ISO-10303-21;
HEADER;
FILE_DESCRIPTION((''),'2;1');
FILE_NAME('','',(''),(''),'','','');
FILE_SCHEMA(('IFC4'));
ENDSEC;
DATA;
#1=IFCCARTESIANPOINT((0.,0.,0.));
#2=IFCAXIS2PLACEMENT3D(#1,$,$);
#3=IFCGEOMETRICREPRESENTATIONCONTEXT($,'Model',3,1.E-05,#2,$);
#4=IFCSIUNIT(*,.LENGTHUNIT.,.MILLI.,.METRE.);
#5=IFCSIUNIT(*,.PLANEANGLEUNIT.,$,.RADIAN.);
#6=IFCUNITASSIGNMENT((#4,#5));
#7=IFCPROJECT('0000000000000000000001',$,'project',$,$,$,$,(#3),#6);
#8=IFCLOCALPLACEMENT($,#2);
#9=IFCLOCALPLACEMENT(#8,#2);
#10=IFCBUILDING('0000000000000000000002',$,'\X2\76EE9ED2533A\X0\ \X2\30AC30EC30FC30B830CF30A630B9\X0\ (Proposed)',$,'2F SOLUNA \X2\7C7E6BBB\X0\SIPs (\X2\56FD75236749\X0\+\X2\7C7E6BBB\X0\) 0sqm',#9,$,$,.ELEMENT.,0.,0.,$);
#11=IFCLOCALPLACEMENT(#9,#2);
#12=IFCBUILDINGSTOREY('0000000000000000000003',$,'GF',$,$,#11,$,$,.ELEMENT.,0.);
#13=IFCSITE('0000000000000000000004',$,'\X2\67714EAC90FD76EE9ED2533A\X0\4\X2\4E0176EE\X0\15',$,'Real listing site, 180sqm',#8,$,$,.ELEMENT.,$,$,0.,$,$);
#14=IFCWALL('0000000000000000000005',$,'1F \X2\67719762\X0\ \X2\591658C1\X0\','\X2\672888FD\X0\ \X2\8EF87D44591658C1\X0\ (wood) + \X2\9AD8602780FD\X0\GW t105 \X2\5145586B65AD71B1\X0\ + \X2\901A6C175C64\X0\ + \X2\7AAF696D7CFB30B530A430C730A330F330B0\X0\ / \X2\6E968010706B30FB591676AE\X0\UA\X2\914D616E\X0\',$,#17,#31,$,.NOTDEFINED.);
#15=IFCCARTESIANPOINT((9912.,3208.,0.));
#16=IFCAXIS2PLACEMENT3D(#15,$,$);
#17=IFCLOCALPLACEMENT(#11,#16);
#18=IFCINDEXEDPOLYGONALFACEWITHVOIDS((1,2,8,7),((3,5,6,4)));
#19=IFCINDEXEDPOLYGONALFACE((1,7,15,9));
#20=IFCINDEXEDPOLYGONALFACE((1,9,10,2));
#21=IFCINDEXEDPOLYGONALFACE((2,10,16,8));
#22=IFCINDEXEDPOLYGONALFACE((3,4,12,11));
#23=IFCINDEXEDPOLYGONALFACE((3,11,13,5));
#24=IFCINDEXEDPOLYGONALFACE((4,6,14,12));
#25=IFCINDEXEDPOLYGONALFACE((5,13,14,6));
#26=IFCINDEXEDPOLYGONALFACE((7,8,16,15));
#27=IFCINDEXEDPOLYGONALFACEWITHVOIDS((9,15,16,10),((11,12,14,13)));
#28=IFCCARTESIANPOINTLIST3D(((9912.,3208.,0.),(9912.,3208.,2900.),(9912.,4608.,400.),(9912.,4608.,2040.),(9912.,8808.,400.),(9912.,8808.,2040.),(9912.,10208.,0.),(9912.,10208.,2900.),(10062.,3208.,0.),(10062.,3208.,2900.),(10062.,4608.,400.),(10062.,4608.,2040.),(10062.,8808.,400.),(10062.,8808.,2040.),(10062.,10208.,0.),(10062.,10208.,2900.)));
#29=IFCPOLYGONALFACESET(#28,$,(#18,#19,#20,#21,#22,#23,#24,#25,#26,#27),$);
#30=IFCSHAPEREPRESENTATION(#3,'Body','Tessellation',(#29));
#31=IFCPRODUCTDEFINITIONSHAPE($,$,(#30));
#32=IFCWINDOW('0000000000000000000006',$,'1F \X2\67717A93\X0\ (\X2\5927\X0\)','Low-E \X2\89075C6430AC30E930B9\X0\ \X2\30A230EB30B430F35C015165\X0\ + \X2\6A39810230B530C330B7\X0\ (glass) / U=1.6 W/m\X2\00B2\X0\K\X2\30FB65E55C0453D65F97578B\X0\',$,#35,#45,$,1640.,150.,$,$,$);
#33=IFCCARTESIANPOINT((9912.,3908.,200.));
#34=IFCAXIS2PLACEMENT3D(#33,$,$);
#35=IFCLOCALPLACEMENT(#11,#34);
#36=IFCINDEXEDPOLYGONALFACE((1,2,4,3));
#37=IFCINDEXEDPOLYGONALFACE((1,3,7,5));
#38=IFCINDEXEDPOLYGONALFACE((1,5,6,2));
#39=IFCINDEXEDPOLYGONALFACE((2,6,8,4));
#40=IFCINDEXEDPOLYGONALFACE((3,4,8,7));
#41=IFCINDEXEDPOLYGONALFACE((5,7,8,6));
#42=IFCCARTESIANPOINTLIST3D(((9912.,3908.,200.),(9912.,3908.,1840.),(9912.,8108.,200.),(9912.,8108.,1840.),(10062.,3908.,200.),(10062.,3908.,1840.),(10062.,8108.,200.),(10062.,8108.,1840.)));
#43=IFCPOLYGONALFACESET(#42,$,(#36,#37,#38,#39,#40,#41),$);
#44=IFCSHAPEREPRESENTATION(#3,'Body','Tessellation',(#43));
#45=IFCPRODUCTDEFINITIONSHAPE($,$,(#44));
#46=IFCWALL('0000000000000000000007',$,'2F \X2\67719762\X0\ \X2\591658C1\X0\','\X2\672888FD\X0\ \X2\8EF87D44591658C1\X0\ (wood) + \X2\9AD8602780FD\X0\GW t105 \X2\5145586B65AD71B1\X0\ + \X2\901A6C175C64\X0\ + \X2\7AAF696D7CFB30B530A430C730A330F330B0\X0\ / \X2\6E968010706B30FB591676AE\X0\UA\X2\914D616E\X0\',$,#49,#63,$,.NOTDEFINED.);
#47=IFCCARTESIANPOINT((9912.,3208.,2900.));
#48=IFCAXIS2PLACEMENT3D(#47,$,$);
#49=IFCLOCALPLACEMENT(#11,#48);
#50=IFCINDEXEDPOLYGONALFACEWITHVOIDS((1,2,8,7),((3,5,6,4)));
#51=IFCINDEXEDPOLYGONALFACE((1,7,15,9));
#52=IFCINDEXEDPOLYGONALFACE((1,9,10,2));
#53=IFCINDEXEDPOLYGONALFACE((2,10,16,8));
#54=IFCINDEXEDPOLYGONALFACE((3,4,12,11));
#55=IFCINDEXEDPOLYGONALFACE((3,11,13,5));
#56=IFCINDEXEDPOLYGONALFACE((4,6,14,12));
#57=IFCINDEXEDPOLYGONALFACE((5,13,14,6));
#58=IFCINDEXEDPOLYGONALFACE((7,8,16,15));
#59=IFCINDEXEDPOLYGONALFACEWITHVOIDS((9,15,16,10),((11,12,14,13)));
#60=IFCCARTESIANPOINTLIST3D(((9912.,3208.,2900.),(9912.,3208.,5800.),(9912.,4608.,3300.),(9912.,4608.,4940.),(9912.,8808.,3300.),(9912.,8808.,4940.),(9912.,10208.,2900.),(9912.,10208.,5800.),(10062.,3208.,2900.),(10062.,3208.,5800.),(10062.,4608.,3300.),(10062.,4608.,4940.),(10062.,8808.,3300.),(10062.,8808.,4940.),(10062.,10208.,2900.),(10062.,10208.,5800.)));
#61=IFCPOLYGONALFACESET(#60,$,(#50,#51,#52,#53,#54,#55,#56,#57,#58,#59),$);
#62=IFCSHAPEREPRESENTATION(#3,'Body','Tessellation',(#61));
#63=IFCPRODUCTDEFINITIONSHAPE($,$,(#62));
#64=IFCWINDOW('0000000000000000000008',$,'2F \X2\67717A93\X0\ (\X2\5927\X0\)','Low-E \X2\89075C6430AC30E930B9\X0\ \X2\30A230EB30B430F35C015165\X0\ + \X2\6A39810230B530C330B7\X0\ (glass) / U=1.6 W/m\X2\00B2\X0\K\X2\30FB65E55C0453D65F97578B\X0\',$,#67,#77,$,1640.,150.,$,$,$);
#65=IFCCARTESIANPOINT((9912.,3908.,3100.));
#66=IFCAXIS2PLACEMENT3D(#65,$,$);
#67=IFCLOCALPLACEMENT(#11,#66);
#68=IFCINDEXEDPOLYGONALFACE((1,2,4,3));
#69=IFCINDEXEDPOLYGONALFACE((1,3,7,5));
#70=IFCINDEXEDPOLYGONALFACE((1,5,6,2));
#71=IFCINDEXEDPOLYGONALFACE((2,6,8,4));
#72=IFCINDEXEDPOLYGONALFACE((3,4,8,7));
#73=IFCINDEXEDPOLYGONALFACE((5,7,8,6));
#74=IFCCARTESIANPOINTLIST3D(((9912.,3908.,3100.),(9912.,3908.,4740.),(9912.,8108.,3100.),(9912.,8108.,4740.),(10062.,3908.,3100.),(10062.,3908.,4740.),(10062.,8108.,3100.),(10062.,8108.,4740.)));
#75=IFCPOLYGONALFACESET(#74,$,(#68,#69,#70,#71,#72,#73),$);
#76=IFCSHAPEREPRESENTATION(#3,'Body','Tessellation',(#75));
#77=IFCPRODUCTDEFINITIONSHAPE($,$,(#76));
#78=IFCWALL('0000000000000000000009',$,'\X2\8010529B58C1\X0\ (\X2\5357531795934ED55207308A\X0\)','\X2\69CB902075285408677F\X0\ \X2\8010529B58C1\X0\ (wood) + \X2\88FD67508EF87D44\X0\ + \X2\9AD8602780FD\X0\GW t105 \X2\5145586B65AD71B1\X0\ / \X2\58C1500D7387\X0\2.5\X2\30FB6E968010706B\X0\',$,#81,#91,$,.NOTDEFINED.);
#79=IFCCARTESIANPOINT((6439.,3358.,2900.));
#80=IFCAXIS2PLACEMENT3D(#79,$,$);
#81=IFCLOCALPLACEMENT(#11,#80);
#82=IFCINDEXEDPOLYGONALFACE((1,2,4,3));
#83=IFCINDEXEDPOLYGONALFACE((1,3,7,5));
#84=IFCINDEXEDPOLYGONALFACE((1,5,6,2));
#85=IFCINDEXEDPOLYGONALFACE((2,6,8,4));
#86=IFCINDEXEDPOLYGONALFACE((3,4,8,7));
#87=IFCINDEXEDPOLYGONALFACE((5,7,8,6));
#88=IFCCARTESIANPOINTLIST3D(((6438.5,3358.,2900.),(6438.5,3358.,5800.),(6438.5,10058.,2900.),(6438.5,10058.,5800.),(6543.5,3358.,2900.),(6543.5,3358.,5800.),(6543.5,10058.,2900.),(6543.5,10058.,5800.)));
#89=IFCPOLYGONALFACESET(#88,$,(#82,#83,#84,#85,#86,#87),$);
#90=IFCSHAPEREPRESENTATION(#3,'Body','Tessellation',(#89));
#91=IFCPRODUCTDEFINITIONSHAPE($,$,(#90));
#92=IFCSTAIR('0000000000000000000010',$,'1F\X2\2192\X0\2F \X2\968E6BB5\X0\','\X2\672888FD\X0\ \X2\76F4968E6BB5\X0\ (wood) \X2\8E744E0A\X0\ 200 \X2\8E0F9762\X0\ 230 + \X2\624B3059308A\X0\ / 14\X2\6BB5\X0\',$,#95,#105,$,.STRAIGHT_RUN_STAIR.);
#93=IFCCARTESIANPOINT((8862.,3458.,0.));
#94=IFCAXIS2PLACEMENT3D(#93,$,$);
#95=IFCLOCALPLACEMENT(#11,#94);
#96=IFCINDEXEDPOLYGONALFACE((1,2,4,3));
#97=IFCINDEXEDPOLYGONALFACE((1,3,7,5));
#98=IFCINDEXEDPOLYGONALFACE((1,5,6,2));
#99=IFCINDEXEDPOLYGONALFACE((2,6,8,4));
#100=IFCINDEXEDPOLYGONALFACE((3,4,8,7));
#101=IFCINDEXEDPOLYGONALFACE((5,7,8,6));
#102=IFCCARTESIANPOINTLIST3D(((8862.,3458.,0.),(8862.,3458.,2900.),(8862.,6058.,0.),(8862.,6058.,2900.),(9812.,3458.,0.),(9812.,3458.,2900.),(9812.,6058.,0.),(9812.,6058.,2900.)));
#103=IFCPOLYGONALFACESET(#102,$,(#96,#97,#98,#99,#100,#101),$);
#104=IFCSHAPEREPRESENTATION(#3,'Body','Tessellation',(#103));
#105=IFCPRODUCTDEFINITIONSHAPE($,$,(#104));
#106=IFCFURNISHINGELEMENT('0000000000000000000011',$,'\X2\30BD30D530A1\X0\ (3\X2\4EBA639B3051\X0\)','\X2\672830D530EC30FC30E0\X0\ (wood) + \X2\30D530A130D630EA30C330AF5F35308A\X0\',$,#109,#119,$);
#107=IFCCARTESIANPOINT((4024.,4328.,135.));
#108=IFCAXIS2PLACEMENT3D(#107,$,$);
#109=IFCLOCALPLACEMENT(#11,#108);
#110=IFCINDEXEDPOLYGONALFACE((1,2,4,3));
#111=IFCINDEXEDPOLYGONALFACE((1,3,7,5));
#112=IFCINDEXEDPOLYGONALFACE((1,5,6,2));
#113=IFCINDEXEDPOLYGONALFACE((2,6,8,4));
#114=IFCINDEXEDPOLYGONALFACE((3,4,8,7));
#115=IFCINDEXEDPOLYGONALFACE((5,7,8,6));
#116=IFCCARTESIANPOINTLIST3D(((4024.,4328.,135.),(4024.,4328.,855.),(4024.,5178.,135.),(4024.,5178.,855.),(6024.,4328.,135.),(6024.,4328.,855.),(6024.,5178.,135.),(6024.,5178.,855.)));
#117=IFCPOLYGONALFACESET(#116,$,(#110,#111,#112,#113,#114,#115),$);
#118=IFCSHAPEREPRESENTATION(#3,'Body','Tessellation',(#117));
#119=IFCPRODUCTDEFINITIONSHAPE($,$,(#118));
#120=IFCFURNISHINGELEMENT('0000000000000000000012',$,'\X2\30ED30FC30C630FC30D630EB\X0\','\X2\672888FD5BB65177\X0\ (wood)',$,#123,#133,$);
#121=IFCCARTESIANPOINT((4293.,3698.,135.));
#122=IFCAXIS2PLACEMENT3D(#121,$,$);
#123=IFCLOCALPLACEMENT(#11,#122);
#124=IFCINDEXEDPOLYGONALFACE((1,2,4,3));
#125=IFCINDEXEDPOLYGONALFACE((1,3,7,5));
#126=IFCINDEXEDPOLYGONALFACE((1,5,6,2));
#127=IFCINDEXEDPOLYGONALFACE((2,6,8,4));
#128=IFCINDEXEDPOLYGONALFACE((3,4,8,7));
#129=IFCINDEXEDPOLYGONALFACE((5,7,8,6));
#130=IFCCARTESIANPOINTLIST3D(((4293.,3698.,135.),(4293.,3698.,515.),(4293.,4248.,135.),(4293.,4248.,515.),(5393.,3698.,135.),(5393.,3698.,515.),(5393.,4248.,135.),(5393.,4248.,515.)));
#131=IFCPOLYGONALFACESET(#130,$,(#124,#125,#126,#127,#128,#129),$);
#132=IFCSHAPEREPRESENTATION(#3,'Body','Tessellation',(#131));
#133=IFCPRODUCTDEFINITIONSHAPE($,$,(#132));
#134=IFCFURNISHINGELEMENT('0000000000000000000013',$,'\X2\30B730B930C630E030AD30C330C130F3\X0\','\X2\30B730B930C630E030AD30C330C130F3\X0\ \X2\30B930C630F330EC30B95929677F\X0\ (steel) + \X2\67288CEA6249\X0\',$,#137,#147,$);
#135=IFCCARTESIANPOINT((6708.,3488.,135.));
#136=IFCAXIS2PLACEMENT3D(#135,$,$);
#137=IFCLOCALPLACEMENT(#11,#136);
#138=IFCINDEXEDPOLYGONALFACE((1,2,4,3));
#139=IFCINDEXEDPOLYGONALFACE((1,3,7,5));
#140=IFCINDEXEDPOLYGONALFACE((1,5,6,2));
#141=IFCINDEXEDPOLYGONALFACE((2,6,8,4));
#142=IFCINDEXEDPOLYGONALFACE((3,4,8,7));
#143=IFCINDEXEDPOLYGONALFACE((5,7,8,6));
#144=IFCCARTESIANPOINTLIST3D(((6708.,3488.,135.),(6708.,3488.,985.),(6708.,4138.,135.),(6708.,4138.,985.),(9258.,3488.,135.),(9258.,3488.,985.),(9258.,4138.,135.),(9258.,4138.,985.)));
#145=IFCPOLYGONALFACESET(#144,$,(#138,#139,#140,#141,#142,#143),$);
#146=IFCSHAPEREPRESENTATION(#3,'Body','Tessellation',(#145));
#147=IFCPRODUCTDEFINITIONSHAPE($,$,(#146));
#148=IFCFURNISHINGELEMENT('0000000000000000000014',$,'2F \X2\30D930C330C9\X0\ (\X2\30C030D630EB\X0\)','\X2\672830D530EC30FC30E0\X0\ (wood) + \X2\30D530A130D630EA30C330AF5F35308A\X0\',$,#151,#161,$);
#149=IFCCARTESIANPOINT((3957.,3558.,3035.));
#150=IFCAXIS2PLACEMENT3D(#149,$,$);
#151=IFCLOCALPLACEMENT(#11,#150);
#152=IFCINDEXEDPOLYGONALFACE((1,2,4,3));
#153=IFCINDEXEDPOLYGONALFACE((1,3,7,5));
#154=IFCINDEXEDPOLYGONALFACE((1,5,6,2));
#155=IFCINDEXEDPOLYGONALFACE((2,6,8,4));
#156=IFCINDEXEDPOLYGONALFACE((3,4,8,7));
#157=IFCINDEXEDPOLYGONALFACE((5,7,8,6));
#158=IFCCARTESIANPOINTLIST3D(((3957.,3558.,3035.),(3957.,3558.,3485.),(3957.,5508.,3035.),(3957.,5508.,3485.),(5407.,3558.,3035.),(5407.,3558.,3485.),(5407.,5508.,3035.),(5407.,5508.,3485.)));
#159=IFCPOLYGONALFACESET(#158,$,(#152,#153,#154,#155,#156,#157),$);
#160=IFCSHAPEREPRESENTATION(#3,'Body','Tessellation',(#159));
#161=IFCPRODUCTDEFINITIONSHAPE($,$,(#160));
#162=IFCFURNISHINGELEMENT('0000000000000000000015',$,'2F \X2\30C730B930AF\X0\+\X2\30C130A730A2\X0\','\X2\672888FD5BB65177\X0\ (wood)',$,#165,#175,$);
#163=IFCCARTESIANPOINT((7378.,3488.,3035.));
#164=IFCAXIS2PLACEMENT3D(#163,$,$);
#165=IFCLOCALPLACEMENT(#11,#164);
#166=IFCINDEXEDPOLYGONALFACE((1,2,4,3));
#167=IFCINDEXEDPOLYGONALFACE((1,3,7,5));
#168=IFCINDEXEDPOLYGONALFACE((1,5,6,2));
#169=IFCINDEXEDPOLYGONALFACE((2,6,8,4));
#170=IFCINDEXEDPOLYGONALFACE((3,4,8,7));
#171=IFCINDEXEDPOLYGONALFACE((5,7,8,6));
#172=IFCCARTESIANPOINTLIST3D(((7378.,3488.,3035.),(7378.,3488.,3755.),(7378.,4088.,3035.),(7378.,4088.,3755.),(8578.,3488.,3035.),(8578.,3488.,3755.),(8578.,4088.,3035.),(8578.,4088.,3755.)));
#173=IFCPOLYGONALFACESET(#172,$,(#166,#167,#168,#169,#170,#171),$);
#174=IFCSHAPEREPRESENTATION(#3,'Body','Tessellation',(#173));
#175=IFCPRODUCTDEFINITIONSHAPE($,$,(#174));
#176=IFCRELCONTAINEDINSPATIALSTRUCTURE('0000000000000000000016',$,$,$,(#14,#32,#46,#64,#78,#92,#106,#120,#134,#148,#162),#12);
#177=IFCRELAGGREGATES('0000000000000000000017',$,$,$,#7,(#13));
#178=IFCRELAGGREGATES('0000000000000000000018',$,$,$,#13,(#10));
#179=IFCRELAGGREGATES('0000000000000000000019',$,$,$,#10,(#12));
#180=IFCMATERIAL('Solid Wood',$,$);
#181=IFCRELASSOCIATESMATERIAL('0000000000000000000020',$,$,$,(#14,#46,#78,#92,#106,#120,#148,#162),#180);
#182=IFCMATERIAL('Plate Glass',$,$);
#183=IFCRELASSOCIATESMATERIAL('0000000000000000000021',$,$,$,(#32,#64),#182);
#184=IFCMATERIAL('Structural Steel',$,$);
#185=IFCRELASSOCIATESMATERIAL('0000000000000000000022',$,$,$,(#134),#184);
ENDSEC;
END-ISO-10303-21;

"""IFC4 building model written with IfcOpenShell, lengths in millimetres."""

from ifc_helpers import new_model, si_unit, frame, frame_2d, origin, place, context, project, spatial, rectangle, extrude, material, element, fill, save


model = new_model("IFC4")

# Units and contexts
model_context = context("Model", 3, precision=1e-05, world=origin())
ifc_project = project(units=[si_unit("LENGTHUNIT", "METRE", prefix="MILLI"), si_unit("PLANEANGLEUNIT", "RADIAN")], contexts=[model_context])

# Site, building, storey
site_placement = place(None, origin())
site = spatial("IfcSite", under=ifc_project, at=site_placement, Name="東京都目黒区4丁目15", ObjectType="Real listing site, 180sqm", CompositionType="ELEMENT", RefElevation=0.0)
building_placement = place(site_placement, origin())
building = spatial("IfcBuilding", under=site, at=building_placement, Name="目黒区 ガレージハウス (Proposed)", ObjectType="2F SOLUNA 籾殻SIPs (国産杉+籾殻) 0sqm", CompositionType="ELEMENT", ElevationOfRefHeight=0.0, ElevationOfTerrain=0.0)
storey_placement = place(building_placement, origin())
storey = spatial("IfcBuildingStorey", under=building, at=storey_placement, Name="GF", CompositionType="ELEMENT", Elevation=0.0)

# Wall, opening, window
ifc_material_1 = material(Name="Solid Wood")
wall_1_placement = place(storey_placement, frame((9912.0, 3208.0, 0.0)))
wall_1 = element("IfcWall", 1, at=wall_1_placement, inside=storey, material=ifc_material_1, Name="1F 東面 外壁", Description="木製 軸組外壁 (wood) + 高性能GW t105 充填断熱 + 通気層 + 窯業系サイディング / 準耐火・外皮UA配慮", PredefinedType="NOTDEFINED", context=model_context, shape_type="SweptSolid", body=[
    extrude(rectangle(XDim=150.0, YDim=7000.0, at=frame_2d((75.0, 3500.0))), frame((9912.0, 3208.0, 0.0)), (0.0, 0.0, 1.0), 2900.0),
])
opening_1_placement = place(storey_placement, frame((9912.0, 3908.0, 200.0)))
opening_1 = element("IfcOpeningElement", 2, at=opening_1_placement, cuts=wall_1, PredefinedType="NOTDEFINED", context=model_context, shape_type="SweptSolid", body=[
    extrude(rectangle(XDim=150.0, YDim=4200.0, at=frame_2d((75.0, 2100.0))), frame((9912.0, 3908.0, 200.0)), (0.0, 0.0, 1.0), 1640.0),
])
ifc_material_2 = material(Name="Plate Glass")
window_1_placement = place(storey_placement, frame((9912.0, 3908.0, 200.0)))
window_1 = element("IfcWindow", 3, at=window_1_placement, inside=storey, material=ifc_material_2, Name="1F 東窓 (大)", Description="Low-E 複層ガラス アルゴン封入 + 樹脂サッシ (glass) / U=1.6 W/m²K・日射取得型", OverallHeight=1640.0, OverallWidth=150.0, context=model_context, shape_type="SweptSolid", body=[
    extrude(rectangle(XDim=150.0, YDim=4200.0, at=frame_2d((75.0, 2100.0))), frame((9912.0, 3908.0, 200.0)), (0.0, 0.0, 1.0), 1640.0),
])
fill(opening_1, window_1)

# Wall, opening, window
wall_2_placement = place(storey_placement, frame((9912.0, 3208.0, 2900.0)))
wall_2 = element("IfcWall", 4, at=wall_2_placement, inside=storey, material=ifc_material_1, Name="2F 東面 外壁", Description="木製 軸組外壁 (wood) + 高性能GW t105 充填断熱 + 通気層 + 窯業系サイディング / 準耐火・外皮UA配慮", PredefinedType="NOTDEFINED", context=model_context, shape_type="SweptSolid", body=[
    extrude(rectangle(XDim=150.0, YDim=7000.0, at=frame_2d((75.0, 3500.0))), frame((9912.0, 3208.0, 2900.0)), (0.0, 0.0, 1.0), 2900.0),
])
opening_2_placement = place(storey_placement, frame((9912.0, 3908.0, 3100.0)))
opening_2 = element("IfcOpeningElement", 5, at=opening_2_placement, cuts=wall_2, PredefinedType="NOTDEFINED", context=model_context, shape_type="SweptSolid", body=[
    extrude(rectangle(XDim=150.0, YDim=4200.0, at=frame_2d((75.0, 2100.0))), frame((9912.0, 3908.0, 3100.0)), (0.0, 0.0, 1.0), 1640.0),
])
window_2_placement = place(storey_placement, frame((9912.0, 3908.0, 3100.0)))
window_2 = element("IfcWindow", 6, at=window_2_placement, inside=storey, material=ifc_material_2, Name="2F 東窓 (大)", Description="Low-E 複層ガラス アルゴン封入 + 樹脂サッシ (glass) / U=1.6 W/m²K・日射取得型", OverallHeight=1640.0, OverallWidth=150.0, context=model_context, shape_type="SweptSolid", body=[
    extrude(rectangle(XDim=150.0, YDim=4200.0, at=frame_2d((75.0, 2100.0))), frame((9912.0, 3908.0, 3100.0)), (0.0, 0.0, 1.0), 1640.0),
])
fill(opening_2, window_2)

# Wall
wall_3_placement = place(storey_placement, frame((6439.0, 3358.0, 2900.0)))
element("IfcWall", 7, at=wall_3_placement, inside=storey, material=ifc_material_1, Name="耐力壁 (南北間仕切り)", Description="構造用合板 耐力壁 (wood) + 製材軸組 + 高性能GW t105 充填断熱 / 壁倍率2.5・準耐火", PredefinedType="NOTDEFINED", context=model_context, shape_type="SweptSolid", body=[
    extrude(rectangle(XDim=105.0, YDim=6700.0, at=frame_2d((52.0, 3350.0))), frame((6439.0, 3358.0, 2900.0)), (0.0, 0.0, 1.0), 2900.0),
])

# Stair
stair_placement = place(storey_placement, frame((8862.0, 3458.0, 0.0)))
element("IfcStair", 8, at=stair_placement, inside=storey, material=ifc_material_1, Name="1F→2F 階段", Description="木製 直階段 (wood) 蹴上 200 踏面 230 + 手すり / 14段", PredefinedType="STRAIGHT_RUN_STAIR", context=model_context, shape_type="SweptSolid", body=[
    extrude(rectangle(XDim=950.0, YDim=2600.0, at=frame_2d((475.0, 1300.0))), frame((8862.0, 3458.0, 0.0)), (0.0, 0.0, 1.0), 2900.0),
])

# Furnishing elements
furnishing_1_placement = place(storey_placement, frame((4024.0, 4328.0, 135.0)))
element("IfcFurnishingElement", 9, at=furnishing_1_placement, inside=storey, material=ifc_material_1, Name="ソファ (3人掛け)", Description="木フレーム (wood) + ファブリック張り", context=model_context, shape_type="SweptSolid", body=[
    extrude(rectangle(XDim=2000.0, YDim=850.0, at=frame_2d((1000.0, 425.0))), frame((4024.0, 4328.0, 135.0)), (0.0, 0.0, 1.0), 720.0),
])
furnishing_2_placement = place(storey_placement, frame((4293.0, 3698.0, 135.0)))
element("IfcFurnishingElement", 10, at=furnishing_2_placement, inside=storey, material=ifc_material_1, Name="ローテーブル", Description="木製家具 (wood)", context=model_context, shape_type="SweptSolid", body=[
    extrude(rectangle(XDim=1100.0, YDim=550.0, at=frame_2d((550.0, 275.0))), frame((4293.0, 3698.0, 135.0)), (0.0, 0.0, 1.0), 380.0),
])
ifc_material_3 = material(Name="Structural Steel")
furnishing_3_placement = place(storey_placement, frame((6708.0, 3488.0, 135.0)))
element("IfcFurnishingElement", 11, at=furnishing_3_placement, inside=storey, material=ifc_material_3, Name="システムキッチン", Description="システムキッチン ステンレス天板 (steel) + 木質扉", context=model_context, shape_type="SweptSolid", body=[
    extrude(rectangle(XDim=2550.0, YDim=650.0, at=frame_2d((1275.0, 325.0))), frame((6708.0, 3488.0, 135.0)), (0.0, 0.0, 1.0), 850.0),
])
furnishing_4_placement = place(storey_placement, frame((3957.0, 3558.0, 3035.0)))
element("IfcFurnishingElement", 12, at=furnishing_4_placement, inside=storey, material=ifc_material_1, Name="2F ベッド (ダブル)", Description="木フレーム (wood) + ファブリック張り", context=model_context, shape_type="SweptSolid", body=[
    extrude(rectangle(XDim=1450.0, YDim=1950.0, at=frame_2d((725.0, 975.0))), frame((3957.0, 3558.0, 3035.0)), (0.0, 0.0, 1.0), 450.0),
])
furnishing_5_placement = place(storey_placement, frame((7378.0, 3488.0, 3035.0)))
element("IfcFurnishingElement", 13, at=furnishing_5_placement, inside=storey, material=ifc_material_1, Name="2F デスク+チェア", Description="木製家具 (wood)", context=model_context, shape_type="SweptSolid", body=[
    extrude(rectangle(XDim=1200.0, YDim=600.0, at=frame_2d((600.0, 300.0))), frame((7378.0, 3488.0, 3035.0)), (0.0, 0.0, 1.0), 720.0),
])

save(model, "model.ifc")
